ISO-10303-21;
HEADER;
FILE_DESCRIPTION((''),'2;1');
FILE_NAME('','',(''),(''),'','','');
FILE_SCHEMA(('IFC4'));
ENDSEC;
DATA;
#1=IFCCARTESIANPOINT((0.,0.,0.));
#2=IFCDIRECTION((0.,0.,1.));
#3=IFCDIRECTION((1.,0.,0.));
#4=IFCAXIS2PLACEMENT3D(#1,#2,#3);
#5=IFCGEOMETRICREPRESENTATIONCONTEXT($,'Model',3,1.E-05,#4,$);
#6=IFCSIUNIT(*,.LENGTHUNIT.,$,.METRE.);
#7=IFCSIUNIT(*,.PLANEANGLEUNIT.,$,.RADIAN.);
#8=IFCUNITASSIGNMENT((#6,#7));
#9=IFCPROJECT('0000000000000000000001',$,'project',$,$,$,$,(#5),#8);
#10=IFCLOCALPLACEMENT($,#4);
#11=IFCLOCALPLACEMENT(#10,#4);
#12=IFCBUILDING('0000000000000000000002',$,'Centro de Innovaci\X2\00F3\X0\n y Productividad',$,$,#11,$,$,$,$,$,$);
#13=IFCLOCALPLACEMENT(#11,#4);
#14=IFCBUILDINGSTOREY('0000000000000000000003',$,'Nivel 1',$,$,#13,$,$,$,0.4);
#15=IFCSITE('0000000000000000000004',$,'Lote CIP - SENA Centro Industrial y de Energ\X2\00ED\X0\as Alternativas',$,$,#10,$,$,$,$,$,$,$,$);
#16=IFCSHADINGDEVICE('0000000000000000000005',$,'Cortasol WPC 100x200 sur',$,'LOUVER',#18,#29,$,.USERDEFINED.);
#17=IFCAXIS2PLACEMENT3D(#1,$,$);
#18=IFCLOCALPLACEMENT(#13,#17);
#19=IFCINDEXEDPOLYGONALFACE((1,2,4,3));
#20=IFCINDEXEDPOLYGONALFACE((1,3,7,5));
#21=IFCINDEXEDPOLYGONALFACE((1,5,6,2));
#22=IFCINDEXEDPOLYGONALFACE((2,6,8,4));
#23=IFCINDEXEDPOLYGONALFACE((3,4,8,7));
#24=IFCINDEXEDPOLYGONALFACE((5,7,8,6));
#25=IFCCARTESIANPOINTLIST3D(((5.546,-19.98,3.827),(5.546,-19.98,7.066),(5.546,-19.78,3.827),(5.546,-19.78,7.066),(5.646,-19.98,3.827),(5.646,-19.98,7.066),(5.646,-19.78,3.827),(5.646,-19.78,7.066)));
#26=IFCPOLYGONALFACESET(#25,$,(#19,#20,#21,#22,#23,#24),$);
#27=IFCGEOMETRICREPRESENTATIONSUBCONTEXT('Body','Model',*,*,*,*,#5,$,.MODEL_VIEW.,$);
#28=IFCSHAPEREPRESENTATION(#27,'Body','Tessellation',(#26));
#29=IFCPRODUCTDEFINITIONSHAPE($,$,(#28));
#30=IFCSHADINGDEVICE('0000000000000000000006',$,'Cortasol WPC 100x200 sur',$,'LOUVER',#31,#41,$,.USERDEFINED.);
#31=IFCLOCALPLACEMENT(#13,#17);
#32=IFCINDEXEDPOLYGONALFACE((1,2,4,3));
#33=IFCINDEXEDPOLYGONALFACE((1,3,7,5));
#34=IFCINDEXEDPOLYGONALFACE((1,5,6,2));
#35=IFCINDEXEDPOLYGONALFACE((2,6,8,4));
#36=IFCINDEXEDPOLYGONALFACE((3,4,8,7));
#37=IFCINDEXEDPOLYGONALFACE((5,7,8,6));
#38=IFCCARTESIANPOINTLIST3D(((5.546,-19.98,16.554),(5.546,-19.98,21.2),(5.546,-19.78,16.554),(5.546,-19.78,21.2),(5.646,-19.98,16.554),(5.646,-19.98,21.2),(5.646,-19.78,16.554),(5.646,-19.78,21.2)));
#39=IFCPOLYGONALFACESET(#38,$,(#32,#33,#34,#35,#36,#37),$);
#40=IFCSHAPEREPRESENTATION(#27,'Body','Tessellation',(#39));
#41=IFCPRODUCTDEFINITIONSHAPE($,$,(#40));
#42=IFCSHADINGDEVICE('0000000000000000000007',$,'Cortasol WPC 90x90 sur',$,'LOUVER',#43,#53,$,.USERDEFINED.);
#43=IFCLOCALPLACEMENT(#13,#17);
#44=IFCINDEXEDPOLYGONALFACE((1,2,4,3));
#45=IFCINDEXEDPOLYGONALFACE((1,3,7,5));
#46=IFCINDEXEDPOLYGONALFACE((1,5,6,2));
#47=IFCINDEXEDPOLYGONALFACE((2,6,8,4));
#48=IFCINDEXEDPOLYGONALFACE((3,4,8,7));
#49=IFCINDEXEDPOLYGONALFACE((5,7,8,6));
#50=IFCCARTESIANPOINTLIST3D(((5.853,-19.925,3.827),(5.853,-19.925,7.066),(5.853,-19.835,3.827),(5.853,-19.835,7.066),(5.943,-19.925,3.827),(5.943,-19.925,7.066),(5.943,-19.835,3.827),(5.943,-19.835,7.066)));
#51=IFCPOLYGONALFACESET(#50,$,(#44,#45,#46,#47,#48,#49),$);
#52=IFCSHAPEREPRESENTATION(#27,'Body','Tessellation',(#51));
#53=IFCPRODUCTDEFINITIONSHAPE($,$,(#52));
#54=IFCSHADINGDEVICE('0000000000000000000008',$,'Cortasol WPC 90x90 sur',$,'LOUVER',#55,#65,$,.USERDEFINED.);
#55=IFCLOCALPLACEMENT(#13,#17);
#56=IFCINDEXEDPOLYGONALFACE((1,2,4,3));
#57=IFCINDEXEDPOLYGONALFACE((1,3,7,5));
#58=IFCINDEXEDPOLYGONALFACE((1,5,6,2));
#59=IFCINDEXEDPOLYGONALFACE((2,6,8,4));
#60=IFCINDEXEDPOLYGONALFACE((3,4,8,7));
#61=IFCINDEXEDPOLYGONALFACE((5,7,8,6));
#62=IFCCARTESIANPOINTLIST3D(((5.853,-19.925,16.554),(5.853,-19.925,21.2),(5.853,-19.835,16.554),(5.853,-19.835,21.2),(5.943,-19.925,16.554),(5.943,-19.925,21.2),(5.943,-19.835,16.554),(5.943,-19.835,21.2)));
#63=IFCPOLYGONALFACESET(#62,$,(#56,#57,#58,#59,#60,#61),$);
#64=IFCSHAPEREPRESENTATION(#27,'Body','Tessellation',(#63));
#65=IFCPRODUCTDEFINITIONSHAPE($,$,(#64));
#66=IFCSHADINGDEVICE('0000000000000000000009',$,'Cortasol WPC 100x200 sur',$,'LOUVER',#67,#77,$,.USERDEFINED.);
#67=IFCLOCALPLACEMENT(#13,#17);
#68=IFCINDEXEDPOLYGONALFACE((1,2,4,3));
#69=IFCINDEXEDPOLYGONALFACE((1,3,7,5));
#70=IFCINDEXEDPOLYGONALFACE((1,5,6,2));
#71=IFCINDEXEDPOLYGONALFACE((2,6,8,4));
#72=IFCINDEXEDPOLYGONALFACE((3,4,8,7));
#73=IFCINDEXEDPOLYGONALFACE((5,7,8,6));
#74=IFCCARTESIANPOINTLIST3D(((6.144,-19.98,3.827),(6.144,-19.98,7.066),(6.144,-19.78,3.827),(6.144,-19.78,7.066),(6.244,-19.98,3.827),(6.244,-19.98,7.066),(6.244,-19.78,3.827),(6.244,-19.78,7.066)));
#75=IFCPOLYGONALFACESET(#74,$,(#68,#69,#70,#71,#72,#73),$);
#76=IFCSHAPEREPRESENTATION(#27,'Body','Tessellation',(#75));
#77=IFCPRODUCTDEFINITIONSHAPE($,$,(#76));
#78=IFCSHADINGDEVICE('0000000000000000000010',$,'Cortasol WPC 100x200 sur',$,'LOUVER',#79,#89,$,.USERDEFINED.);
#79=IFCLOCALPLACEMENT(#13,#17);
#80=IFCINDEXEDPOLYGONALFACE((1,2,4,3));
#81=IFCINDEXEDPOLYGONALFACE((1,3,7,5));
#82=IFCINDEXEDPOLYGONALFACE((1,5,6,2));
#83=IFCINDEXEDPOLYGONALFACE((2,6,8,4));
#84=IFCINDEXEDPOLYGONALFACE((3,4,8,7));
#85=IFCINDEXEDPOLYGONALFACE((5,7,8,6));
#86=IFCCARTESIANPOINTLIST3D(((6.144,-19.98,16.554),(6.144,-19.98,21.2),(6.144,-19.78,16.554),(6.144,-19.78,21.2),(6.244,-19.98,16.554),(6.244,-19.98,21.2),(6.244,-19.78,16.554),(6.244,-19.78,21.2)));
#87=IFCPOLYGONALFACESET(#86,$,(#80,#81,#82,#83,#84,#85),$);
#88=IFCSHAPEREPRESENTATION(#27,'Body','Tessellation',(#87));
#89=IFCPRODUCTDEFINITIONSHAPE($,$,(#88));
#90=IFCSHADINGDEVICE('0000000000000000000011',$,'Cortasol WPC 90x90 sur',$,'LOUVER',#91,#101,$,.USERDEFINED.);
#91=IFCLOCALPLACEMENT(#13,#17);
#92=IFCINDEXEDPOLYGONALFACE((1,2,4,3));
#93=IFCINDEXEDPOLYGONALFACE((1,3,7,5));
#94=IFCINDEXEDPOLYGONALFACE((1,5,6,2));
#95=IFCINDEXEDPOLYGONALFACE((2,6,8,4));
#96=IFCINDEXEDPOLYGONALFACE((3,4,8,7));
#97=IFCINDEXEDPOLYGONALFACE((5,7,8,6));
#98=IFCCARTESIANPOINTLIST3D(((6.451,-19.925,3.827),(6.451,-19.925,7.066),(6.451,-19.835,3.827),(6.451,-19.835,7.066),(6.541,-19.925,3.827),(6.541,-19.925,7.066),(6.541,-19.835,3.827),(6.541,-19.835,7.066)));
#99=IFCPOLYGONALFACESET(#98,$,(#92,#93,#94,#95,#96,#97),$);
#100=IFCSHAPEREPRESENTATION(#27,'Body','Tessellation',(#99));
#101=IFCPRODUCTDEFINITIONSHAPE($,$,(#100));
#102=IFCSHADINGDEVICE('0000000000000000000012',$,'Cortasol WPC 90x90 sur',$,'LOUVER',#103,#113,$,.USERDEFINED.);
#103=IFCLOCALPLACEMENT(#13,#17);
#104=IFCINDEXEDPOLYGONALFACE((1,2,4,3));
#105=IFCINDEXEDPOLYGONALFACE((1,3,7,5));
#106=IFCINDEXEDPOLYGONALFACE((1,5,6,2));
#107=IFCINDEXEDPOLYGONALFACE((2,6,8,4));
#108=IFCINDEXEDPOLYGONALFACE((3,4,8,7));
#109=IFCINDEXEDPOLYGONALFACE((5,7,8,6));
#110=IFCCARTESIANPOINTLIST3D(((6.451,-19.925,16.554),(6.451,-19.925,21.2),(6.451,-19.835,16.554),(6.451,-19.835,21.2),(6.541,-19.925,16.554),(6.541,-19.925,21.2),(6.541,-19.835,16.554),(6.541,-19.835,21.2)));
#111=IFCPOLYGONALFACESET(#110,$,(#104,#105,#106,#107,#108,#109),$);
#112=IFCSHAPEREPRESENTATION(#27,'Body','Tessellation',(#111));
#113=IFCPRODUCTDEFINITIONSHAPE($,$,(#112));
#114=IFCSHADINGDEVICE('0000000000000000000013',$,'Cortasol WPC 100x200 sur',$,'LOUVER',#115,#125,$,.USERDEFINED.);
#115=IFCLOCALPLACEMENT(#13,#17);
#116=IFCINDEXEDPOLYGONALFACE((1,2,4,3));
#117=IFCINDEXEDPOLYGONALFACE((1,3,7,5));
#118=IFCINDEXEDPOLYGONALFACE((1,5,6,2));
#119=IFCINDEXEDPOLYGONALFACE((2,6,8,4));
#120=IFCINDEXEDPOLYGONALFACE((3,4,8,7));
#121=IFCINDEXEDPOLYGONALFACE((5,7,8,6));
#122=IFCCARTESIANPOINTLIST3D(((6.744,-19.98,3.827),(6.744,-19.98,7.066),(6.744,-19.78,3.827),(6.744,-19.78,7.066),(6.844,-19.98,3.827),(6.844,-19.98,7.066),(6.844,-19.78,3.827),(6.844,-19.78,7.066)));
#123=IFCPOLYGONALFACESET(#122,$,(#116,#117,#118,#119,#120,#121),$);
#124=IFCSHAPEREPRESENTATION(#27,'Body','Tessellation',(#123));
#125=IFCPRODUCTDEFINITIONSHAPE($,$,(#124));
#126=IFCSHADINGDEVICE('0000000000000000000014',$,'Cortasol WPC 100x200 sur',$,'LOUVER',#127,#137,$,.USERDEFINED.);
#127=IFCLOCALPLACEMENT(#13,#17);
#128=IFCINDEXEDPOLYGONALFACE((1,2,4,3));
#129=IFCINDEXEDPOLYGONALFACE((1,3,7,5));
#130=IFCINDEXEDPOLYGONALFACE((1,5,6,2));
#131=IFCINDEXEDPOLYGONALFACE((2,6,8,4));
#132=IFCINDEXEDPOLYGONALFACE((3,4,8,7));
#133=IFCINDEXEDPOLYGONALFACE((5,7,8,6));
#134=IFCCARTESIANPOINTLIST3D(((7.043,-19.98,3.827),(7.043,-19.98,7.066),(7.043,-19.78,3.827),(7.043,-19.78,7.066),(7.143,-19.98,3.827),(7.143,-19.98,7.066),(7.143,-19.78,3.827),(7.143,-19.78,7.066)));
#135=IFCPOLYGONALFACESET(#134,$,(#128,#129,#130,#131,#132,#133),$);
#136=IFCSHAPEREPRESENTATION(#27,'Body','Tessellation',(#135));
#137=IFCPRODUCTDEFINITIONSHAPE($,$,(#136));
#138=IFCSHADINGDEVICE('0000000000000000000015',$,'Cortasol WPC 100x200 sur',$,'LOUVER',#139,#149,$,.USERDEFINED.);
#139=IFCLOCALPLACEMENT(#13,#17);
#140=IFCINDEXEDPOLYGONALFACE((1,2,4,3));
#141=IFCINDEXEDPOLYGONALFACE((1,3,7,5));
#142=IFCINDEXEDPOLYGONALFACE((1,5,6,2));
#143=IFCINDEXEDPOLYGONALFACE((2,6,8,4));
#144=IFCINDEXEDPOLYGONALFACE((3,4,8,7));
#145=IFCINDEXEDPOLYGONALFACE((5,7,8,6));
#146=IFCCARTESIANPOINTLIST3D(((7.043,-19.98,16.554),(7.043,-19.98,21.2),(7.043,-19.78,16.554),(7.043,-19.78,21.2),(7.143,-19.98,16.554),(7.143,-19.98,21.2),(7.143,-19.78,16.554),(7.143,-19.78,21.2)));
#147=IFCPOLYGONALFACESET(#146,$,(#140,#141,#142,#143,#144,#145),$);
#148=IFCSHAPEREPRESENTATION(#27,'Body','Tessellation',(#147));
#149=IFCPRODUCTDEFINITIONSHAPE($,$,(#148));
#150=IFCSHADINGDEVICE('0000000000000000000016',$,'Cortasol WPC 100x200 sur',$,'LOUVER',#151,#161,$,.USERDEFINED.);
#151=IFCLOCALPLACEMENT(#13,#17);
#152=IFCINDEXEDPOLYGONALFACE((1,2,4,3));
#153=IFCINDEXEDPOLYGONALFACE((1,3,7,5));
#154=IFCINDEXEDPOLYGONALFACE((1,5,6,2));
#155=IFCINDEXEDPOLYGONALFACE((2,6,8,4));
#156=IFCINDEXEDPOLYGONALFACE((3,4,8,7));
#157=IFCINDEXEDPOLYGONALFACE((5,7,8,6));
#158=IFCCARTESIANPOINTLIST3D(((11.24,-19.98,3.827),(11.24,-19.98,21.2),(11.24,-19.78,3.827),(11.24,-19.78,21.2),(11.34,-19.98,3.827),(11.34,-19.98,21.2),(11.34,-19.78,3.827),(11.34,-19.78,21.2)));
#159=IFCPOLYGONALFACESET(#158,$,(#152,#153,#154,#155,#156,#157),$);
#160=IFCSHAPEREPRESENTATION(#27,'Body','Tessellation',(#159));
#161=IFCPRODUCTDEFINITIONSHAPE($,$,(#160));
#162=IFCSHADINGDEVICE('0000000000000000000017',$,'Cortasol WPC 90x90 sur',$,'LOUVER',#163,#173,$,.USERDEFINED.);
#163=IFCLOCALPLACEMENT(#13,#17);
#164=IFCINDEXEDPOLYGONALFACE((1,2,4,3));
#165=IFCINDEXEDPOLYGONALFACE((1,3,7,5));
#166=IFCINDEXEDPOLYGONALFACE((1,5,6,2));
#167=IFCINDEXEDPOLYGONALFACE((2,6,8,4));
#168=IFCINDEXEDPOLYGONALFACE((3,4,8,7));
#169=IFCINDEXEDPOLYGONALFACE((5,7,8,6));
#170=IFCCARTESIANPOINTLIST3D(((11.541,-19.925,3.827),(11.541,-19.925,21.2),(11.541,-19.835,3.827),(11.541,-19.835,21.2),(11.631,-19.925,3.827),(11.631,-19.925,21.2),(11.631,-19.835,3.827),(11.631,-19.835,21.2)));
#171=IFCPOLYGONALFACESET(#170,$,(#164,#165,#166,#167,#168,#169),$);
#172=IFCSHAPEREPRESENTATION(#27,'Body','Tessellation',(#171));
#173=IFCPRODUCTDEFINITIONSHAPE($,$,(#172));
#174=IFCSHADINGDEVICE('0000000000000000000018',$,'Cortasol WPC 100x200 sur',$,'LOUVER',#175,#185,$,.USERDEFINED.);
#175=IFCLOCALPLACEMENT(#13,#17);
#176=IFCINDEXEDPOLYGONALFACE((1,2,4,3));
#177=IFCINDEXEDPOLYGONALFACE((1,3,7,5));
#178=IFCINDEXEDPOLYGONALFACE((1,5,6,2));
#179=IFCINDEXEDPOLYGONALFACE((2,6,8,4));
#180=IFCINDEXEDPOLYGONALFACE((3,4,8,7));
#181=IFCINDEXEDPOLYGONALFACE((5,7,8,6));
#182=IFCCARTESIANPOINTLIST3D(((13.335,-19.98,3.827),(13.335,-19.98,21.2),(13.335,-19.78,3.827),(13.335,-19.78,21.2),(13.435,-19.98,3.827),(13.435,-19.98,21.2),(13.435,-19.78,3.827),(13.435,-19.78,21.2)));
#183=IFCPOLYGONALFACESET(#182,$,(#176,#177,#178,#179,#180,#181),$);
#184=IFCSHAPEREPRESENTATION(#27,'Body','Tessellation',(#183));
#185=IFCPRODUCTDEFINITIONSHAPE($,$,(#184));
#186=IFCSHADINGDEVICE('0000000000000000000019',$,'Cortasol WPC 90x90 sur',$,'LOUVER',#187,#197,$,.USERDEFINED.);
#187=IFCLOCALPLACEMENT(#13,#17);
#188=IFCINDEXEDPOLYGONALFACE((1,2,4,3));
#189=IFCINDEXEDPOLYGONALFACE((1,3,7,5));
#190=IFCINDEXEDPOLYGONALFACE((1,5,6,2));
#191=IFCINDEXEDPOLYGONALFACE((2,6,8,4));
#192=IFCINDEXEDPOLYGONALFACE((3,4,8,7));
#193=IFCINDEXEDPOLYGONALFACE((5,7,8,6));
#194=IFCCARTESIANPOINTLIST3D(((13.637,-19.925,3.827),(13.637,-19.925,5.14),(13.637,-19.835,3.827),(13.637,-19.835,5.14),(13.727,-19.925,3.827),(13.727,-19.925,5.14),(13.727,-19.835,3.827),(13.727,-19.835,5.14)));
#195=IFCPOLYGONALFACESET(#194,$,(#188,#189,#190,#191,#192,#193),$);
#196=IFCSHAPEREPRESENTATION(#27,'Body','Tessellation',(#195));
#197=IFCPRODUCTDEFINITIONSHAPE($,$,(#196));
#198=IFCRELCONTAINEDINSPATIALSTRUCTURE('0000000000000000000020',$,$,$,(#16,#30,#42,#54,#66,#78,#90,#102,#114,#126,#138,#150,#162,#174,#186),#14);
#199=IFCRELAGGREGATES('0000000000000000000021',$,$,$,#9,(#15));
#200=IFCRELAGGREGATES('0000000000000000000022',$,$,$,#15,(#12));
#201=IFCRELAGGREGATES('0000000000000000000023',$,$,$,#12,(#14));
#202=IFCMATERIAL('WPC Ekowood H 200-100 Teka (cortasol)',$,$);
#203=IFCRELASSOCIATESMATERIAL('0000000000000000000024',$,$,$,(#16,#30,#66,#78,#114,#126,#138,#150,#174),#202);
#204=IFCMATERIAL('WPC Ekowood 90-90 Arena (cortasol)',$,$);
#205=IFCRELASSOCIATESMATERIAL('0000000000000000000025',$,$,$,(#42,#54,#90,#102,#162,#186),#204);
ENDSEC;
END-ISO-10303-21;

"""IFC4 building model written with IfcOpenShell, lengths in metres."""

from ifc_helpers import new_model, si_unit, frame, origin_with_axes, place, context, subcontext, project, spatial, polyline, outline, extrude, material, element, save


model = new_model("IFC4")

# Units and contexts
model_context = context("Model", 3, precision=1e-05, world=origin_with_axes())
body_context = subcontext(model_context, "Body", "Model", "MODEL_VIEW")
ifc_project = project(units=[si_unit("LENGTHUNIT", "METRE"), si_unit("PLANEANGLEUNIT", "RADIAN")], contexts=[model_context])

# Site, building, storey
site_placement = place(None, origin_with_axes())
site = spatial("IfcSite", under=ifc_project, at=site_placement, Name="Lote CIP - SENA Centro Industrial y de Energías Alternativas")
building_placement = place(site_placement, origin_with_axes())
building = spatial("IfcBuilding", under=site, at=building_placement, Name="Centro de Innovación y Productividad")
storey_placement = place(building_placement, origin_with_axes())
storey = spatial("IfcBuildingStorey", under=building, at=storey_placement, Name="Nivel 1", Elevation=0.4)

# Shading devices
ifc_material_1 = material(Name="WPC Ekowood H 200-100 Teka (cortasol)")
shading_device_1_placement = place(storey_placement, origin_with_axes())
element("IfcShadingDevice", 1, at=shading_device_1_placement, inside=storey, material=ifc_material_1, Name="Cortasol WPC 100x200 sur", ObjectType="LOUVER", PredefinedType="USERDEFINED", context=body_context, shape_type="SweptSolid", body=[
    extrude(outline(polyline([(5.546, -19.98), (5.546, -19.78), (5.646, -19.78), (5.646, -19.98), (5.546, -19.98)])), frame((0.0, 0.0, 3.827)), (0.0, 0.0, 1.0), 3.239),
])
shading_device_2_placement = place(storey_placement, origin_with_axes())
element("IfcShadingDevice", 2, at=shading_device_2_placement, inside=storey, material=ifc_material_1, Name="Cortasol WPC 100x200 sur", ObjectType="LOUVER", PredefinedType="USERDEFINED", context=body_context, shape_type="SweptSolid", body=[
    extrude(outline(polyline([(5.546, -19.98), (5.546, -19.78), (5.646, -19.78), (5.646, -19.98), (5.546, -19.98)])), frame((0.0, 0.0, 16.554)), (0.0, 0.0, 1.0), 4.646),
])
ifc_material_2 = material(Name="WPC Ekowood 90-90 Arena (cortasol)")
shading_device_3_placement = place(storey_placement, origin_with_axes())
element("IfcShadingDevice", 3, at=shading_device_3_placement, inside=storey, material=ifc_material_2, Name="Cortasol WPC 90x90 sur", ObjectType="LOUVER", PredefinedType="USERDEFINED", context=body_context, shape_type="SweptSolid", body=[
    extrude(outline(polyline([(5.853, -19.925), (5.853, -19.835), (5.943, -19.835), (5.943, -19.925), (5.853, -19.925)])), frame((0.0, 0.0, 3.827)), (0.0, 0.0, 1.0), 3.239),
])
shading_device_4_placement = place(storey_placement, origin_with_axes())
element("IfcShadingDevice", 4, at=shading_device_4_placement, inside=storey, material=ifc_material_2, Name="Cortasol WPC 90x90 sur", ObjectType="LOUVER", PredefinedType="USERDEFINED", context=body_context, shape_type="SweptSolid", body=[
    extrude(outline(polyline([(5.853, -19.925), (5.853, -19.835), (5.943, -19.835), (5.943, -19.925), (5.853, -19.925)])), frame((0.0, 0.0, 16.554)), (0.0, 0.0, 1.0), 4.646),
])
shading_device_5_placement = place(storey_placement, origin_with_axes())
element("IfcShadingDevice", 5, at=shading_device_5_placement, inside=storey, material=ifc_material_1, Name="Cortasol WPC 100x200 sur", ObjectType="LOUVER", PredefinedType="USERDEFINED", context=body_context, shape_type="SweptSolid", body=[
    extrude(outline(polyline([(6.144, -19.98), (6.144, -19.78), (6.244, -19.78), (6.244, -19.98), (6.144, -19.98)])), frame((0.0, 0.0, 3.827)), (0.0, 0.0, 1.0), 3.239),
])
shading_device_6_placement = place(storey_placement, origin_with_axes())
element("IfcShadingDevice", 6, at=shading_device_6_placement, inside=storey, material=ifc_material_1, Name="Cortasol WPC 100x200 sur", ObjectType="LOUVER", PredefinedType="USERDEFINED", context=body_context, shape_type="SweptSolid", body=[
    extrude(outline(polyline([(6.144, -19.98), (6.144, -19.78), (6.244, -19.78), (6.244, -19.98), (6.144, -19.98)])), frame((0.0, 0.0, 16.554)), (0.0, 0.0, 1.0), 4.646),
])
shading_device_7_placement = place(storey_placement, origin_with_axes())
element("IfcShadingDevice", 7, at=shading_device_7_placement, inside=storey, material=ifc_material_2, Name="Cortasol WPC 90x90 sur", ObjectType="LOUVER", PredefinedType="USERDEFINED", context=body_context, shape_type="SweptSolid", body=[
    extrude(outline(polyline([(6.451, -19.925), (6.451, -19.835), (6.541, -19.835), (6.541, -19.925), (6.451, -19.925)])), frame((0.0, 0.0, 3.827)), (0.0, 0.0, 1.0), 3.239),
])
shading_device_8_placement = place(storey_placement, origin_with_axes())
element("IfcShadingDevice", 8, at=shading_device_8_placement, inside=storey, material=ifc_material_2, Name="Cortasol WPC 90x90 sur", ObjectType="LOUVER", PredefinedType="USERDEFINED", context=body_context, shape_type="SweptSolid", body=[
    extrude(outline(polyline([(6.451, -19.925), (6.451, -19.835), (6.541, -19.835), (6.541, -19.925), (6.451, -19.925)])), frame((0.0, 0.0, 16.554)), (0.0, 0.0, 1.0), 4.646),
])
shading_device_9_placement = place(storey_placement, origin_with_axes())
element("IfcShadingDevice", 9, at=shading_device_9_placement, inside=storey, material=ifc_material_1, Name="Cortasol WPC 100x200 sur", ObjectType="LOUVER", PredefinedType="USERDEFINED", context=body_context, shape_type="SweptSolid", body=[
    extrude(outline(polyline([(6.744, -19.98), (6.744, -19.78), (6.844, -19.78), (6.844, -19.98), (6.744, -19.98)])), frame((0.0, 0.0, 3.827)), (0.0, 0.0, 1.0), 3.239),
])
shading_device_10_placement = place(storey_placement, origin_with_axes())
element("IfcShadingDevice", 10, at=shading_device_10_placement, inside=storey, material=ifc_material_1, Name="Cortasol WPC 100x200 sur", ObjectType="LOUVER", PredefinedType="USERDEFINED", context=body_context, shape_type="SweptSolid", body=[
    extrude(outline(polyline([(7.043, -19.98), (7.043, -19.78), (7.143, -19.78), (7.143, -19.98), (7.043, -19.98)])), frame((0.0, 0.0, 3.827)), (0.0, 0.0, 1.0), 3.239),
])
shading_device_11_placement = place(storey_placement, origin_with_axes())
element("IfcShadingDevice", 11, at=shading_device_11_placement, inside=storey, material=ifc_material_1, Name="Cortasol WPC 100x200 sur", ObjectType="LOUVER", PredefinedType="USERDEFINED", context=body_context, shape_type="SweptSolid", body=[
    extrude(outline(polyline([(7.043, -19.98), (7.043, -19.78), (7.143, -19.78), (7.143, -19.98), (7.043, -19.98)])), frame((0.0, 0.0, 16.554)), (0.0, 0.0, 1.0), 4.646),
])
shading_device_12_placement = place(storey_placement, origin_with_axes())
element("IfcShadingDevice", 12, at=shading_device_12_placement, inside=storey, material=ifc_material_1, Name="Cortasol WPC 100x200 sur", ObjectType="LOUVER", PredefinedType="USERDEFINED", context=body_context, shape_type="SweptSolid", body=[
    extrude(outline(polyline([(11.24, -19.98), (11.24, -19.78), (11.34, -19.78), (11.34, -19.98), (11.24, -19.98)])), frame((0.0, 0.0, 3.827)), (0.0, 0.0, 1.0), 17.373),
])
shading_device_13_placement = place(storey_placement, origin_with_axes())
element("IfcShadingDevice", 13, at=shading_device_13_placement, inside=storey, material=ifc_material_2, Name="Cortasol WPC 90x90 sur", ObjectType="LOUVER", PredefinedType="USERDEFINED", context=body_context, shape_type="SweptSolid", body=[
    extrude(outline(polyline([(11.541, -19.925), (11.541, -19.835), (11.631, -19.835), (11.631, -19.925), (11.541, -19.925)])), frame((0.0, 0.0, 3.827)), (0.0, 0.0, 1.0), 17.373),
])
shading_device_14_placement = place(storey_placement, origin_with_axes())
element("IfcShadingDevice", 14, at=shading_device_14_placement, inside=storey, material=ifc_material_1, Name="Cortasol WPC 100x200 sur", ObjectType="LOUVER", PredefinedType="USERDEFINED", context=body_context, shape_type="SweptSolid", body=[
    extrude(outline(polyline([(13.335, -19.98), (13.335, -19.78), (13.435, -19.78), (13.435, -19.98), (13.335, -19.98)])), frame((0.0, 0.0, 3.827)), (0.0, 0.0, 1.0), 17.373),
])
shading_device_15_placement = place(storey_placement, origin_with_axes())
element("IfcShadingDevice", 15, at=shading_device_15_placement, inside=storey, material=ifc_material_2, Name="Cortasol WPC 90x90 sur", ObjectType="LOUVER", PredefinedType="USERDEFINED", context=body_context, shape_type="SweptSolid", body=[
    extrude(outline(polyline([(13.637, -19.925), (13.637, -19.835), (13.727, -19.835), (13.727, -19.925), (13.637, -19.925)])), frame((0.0, 0.0, 3.827)), (0.0, 0.0, 1.0), 1.313),
])

save(model, "model.ifc")
